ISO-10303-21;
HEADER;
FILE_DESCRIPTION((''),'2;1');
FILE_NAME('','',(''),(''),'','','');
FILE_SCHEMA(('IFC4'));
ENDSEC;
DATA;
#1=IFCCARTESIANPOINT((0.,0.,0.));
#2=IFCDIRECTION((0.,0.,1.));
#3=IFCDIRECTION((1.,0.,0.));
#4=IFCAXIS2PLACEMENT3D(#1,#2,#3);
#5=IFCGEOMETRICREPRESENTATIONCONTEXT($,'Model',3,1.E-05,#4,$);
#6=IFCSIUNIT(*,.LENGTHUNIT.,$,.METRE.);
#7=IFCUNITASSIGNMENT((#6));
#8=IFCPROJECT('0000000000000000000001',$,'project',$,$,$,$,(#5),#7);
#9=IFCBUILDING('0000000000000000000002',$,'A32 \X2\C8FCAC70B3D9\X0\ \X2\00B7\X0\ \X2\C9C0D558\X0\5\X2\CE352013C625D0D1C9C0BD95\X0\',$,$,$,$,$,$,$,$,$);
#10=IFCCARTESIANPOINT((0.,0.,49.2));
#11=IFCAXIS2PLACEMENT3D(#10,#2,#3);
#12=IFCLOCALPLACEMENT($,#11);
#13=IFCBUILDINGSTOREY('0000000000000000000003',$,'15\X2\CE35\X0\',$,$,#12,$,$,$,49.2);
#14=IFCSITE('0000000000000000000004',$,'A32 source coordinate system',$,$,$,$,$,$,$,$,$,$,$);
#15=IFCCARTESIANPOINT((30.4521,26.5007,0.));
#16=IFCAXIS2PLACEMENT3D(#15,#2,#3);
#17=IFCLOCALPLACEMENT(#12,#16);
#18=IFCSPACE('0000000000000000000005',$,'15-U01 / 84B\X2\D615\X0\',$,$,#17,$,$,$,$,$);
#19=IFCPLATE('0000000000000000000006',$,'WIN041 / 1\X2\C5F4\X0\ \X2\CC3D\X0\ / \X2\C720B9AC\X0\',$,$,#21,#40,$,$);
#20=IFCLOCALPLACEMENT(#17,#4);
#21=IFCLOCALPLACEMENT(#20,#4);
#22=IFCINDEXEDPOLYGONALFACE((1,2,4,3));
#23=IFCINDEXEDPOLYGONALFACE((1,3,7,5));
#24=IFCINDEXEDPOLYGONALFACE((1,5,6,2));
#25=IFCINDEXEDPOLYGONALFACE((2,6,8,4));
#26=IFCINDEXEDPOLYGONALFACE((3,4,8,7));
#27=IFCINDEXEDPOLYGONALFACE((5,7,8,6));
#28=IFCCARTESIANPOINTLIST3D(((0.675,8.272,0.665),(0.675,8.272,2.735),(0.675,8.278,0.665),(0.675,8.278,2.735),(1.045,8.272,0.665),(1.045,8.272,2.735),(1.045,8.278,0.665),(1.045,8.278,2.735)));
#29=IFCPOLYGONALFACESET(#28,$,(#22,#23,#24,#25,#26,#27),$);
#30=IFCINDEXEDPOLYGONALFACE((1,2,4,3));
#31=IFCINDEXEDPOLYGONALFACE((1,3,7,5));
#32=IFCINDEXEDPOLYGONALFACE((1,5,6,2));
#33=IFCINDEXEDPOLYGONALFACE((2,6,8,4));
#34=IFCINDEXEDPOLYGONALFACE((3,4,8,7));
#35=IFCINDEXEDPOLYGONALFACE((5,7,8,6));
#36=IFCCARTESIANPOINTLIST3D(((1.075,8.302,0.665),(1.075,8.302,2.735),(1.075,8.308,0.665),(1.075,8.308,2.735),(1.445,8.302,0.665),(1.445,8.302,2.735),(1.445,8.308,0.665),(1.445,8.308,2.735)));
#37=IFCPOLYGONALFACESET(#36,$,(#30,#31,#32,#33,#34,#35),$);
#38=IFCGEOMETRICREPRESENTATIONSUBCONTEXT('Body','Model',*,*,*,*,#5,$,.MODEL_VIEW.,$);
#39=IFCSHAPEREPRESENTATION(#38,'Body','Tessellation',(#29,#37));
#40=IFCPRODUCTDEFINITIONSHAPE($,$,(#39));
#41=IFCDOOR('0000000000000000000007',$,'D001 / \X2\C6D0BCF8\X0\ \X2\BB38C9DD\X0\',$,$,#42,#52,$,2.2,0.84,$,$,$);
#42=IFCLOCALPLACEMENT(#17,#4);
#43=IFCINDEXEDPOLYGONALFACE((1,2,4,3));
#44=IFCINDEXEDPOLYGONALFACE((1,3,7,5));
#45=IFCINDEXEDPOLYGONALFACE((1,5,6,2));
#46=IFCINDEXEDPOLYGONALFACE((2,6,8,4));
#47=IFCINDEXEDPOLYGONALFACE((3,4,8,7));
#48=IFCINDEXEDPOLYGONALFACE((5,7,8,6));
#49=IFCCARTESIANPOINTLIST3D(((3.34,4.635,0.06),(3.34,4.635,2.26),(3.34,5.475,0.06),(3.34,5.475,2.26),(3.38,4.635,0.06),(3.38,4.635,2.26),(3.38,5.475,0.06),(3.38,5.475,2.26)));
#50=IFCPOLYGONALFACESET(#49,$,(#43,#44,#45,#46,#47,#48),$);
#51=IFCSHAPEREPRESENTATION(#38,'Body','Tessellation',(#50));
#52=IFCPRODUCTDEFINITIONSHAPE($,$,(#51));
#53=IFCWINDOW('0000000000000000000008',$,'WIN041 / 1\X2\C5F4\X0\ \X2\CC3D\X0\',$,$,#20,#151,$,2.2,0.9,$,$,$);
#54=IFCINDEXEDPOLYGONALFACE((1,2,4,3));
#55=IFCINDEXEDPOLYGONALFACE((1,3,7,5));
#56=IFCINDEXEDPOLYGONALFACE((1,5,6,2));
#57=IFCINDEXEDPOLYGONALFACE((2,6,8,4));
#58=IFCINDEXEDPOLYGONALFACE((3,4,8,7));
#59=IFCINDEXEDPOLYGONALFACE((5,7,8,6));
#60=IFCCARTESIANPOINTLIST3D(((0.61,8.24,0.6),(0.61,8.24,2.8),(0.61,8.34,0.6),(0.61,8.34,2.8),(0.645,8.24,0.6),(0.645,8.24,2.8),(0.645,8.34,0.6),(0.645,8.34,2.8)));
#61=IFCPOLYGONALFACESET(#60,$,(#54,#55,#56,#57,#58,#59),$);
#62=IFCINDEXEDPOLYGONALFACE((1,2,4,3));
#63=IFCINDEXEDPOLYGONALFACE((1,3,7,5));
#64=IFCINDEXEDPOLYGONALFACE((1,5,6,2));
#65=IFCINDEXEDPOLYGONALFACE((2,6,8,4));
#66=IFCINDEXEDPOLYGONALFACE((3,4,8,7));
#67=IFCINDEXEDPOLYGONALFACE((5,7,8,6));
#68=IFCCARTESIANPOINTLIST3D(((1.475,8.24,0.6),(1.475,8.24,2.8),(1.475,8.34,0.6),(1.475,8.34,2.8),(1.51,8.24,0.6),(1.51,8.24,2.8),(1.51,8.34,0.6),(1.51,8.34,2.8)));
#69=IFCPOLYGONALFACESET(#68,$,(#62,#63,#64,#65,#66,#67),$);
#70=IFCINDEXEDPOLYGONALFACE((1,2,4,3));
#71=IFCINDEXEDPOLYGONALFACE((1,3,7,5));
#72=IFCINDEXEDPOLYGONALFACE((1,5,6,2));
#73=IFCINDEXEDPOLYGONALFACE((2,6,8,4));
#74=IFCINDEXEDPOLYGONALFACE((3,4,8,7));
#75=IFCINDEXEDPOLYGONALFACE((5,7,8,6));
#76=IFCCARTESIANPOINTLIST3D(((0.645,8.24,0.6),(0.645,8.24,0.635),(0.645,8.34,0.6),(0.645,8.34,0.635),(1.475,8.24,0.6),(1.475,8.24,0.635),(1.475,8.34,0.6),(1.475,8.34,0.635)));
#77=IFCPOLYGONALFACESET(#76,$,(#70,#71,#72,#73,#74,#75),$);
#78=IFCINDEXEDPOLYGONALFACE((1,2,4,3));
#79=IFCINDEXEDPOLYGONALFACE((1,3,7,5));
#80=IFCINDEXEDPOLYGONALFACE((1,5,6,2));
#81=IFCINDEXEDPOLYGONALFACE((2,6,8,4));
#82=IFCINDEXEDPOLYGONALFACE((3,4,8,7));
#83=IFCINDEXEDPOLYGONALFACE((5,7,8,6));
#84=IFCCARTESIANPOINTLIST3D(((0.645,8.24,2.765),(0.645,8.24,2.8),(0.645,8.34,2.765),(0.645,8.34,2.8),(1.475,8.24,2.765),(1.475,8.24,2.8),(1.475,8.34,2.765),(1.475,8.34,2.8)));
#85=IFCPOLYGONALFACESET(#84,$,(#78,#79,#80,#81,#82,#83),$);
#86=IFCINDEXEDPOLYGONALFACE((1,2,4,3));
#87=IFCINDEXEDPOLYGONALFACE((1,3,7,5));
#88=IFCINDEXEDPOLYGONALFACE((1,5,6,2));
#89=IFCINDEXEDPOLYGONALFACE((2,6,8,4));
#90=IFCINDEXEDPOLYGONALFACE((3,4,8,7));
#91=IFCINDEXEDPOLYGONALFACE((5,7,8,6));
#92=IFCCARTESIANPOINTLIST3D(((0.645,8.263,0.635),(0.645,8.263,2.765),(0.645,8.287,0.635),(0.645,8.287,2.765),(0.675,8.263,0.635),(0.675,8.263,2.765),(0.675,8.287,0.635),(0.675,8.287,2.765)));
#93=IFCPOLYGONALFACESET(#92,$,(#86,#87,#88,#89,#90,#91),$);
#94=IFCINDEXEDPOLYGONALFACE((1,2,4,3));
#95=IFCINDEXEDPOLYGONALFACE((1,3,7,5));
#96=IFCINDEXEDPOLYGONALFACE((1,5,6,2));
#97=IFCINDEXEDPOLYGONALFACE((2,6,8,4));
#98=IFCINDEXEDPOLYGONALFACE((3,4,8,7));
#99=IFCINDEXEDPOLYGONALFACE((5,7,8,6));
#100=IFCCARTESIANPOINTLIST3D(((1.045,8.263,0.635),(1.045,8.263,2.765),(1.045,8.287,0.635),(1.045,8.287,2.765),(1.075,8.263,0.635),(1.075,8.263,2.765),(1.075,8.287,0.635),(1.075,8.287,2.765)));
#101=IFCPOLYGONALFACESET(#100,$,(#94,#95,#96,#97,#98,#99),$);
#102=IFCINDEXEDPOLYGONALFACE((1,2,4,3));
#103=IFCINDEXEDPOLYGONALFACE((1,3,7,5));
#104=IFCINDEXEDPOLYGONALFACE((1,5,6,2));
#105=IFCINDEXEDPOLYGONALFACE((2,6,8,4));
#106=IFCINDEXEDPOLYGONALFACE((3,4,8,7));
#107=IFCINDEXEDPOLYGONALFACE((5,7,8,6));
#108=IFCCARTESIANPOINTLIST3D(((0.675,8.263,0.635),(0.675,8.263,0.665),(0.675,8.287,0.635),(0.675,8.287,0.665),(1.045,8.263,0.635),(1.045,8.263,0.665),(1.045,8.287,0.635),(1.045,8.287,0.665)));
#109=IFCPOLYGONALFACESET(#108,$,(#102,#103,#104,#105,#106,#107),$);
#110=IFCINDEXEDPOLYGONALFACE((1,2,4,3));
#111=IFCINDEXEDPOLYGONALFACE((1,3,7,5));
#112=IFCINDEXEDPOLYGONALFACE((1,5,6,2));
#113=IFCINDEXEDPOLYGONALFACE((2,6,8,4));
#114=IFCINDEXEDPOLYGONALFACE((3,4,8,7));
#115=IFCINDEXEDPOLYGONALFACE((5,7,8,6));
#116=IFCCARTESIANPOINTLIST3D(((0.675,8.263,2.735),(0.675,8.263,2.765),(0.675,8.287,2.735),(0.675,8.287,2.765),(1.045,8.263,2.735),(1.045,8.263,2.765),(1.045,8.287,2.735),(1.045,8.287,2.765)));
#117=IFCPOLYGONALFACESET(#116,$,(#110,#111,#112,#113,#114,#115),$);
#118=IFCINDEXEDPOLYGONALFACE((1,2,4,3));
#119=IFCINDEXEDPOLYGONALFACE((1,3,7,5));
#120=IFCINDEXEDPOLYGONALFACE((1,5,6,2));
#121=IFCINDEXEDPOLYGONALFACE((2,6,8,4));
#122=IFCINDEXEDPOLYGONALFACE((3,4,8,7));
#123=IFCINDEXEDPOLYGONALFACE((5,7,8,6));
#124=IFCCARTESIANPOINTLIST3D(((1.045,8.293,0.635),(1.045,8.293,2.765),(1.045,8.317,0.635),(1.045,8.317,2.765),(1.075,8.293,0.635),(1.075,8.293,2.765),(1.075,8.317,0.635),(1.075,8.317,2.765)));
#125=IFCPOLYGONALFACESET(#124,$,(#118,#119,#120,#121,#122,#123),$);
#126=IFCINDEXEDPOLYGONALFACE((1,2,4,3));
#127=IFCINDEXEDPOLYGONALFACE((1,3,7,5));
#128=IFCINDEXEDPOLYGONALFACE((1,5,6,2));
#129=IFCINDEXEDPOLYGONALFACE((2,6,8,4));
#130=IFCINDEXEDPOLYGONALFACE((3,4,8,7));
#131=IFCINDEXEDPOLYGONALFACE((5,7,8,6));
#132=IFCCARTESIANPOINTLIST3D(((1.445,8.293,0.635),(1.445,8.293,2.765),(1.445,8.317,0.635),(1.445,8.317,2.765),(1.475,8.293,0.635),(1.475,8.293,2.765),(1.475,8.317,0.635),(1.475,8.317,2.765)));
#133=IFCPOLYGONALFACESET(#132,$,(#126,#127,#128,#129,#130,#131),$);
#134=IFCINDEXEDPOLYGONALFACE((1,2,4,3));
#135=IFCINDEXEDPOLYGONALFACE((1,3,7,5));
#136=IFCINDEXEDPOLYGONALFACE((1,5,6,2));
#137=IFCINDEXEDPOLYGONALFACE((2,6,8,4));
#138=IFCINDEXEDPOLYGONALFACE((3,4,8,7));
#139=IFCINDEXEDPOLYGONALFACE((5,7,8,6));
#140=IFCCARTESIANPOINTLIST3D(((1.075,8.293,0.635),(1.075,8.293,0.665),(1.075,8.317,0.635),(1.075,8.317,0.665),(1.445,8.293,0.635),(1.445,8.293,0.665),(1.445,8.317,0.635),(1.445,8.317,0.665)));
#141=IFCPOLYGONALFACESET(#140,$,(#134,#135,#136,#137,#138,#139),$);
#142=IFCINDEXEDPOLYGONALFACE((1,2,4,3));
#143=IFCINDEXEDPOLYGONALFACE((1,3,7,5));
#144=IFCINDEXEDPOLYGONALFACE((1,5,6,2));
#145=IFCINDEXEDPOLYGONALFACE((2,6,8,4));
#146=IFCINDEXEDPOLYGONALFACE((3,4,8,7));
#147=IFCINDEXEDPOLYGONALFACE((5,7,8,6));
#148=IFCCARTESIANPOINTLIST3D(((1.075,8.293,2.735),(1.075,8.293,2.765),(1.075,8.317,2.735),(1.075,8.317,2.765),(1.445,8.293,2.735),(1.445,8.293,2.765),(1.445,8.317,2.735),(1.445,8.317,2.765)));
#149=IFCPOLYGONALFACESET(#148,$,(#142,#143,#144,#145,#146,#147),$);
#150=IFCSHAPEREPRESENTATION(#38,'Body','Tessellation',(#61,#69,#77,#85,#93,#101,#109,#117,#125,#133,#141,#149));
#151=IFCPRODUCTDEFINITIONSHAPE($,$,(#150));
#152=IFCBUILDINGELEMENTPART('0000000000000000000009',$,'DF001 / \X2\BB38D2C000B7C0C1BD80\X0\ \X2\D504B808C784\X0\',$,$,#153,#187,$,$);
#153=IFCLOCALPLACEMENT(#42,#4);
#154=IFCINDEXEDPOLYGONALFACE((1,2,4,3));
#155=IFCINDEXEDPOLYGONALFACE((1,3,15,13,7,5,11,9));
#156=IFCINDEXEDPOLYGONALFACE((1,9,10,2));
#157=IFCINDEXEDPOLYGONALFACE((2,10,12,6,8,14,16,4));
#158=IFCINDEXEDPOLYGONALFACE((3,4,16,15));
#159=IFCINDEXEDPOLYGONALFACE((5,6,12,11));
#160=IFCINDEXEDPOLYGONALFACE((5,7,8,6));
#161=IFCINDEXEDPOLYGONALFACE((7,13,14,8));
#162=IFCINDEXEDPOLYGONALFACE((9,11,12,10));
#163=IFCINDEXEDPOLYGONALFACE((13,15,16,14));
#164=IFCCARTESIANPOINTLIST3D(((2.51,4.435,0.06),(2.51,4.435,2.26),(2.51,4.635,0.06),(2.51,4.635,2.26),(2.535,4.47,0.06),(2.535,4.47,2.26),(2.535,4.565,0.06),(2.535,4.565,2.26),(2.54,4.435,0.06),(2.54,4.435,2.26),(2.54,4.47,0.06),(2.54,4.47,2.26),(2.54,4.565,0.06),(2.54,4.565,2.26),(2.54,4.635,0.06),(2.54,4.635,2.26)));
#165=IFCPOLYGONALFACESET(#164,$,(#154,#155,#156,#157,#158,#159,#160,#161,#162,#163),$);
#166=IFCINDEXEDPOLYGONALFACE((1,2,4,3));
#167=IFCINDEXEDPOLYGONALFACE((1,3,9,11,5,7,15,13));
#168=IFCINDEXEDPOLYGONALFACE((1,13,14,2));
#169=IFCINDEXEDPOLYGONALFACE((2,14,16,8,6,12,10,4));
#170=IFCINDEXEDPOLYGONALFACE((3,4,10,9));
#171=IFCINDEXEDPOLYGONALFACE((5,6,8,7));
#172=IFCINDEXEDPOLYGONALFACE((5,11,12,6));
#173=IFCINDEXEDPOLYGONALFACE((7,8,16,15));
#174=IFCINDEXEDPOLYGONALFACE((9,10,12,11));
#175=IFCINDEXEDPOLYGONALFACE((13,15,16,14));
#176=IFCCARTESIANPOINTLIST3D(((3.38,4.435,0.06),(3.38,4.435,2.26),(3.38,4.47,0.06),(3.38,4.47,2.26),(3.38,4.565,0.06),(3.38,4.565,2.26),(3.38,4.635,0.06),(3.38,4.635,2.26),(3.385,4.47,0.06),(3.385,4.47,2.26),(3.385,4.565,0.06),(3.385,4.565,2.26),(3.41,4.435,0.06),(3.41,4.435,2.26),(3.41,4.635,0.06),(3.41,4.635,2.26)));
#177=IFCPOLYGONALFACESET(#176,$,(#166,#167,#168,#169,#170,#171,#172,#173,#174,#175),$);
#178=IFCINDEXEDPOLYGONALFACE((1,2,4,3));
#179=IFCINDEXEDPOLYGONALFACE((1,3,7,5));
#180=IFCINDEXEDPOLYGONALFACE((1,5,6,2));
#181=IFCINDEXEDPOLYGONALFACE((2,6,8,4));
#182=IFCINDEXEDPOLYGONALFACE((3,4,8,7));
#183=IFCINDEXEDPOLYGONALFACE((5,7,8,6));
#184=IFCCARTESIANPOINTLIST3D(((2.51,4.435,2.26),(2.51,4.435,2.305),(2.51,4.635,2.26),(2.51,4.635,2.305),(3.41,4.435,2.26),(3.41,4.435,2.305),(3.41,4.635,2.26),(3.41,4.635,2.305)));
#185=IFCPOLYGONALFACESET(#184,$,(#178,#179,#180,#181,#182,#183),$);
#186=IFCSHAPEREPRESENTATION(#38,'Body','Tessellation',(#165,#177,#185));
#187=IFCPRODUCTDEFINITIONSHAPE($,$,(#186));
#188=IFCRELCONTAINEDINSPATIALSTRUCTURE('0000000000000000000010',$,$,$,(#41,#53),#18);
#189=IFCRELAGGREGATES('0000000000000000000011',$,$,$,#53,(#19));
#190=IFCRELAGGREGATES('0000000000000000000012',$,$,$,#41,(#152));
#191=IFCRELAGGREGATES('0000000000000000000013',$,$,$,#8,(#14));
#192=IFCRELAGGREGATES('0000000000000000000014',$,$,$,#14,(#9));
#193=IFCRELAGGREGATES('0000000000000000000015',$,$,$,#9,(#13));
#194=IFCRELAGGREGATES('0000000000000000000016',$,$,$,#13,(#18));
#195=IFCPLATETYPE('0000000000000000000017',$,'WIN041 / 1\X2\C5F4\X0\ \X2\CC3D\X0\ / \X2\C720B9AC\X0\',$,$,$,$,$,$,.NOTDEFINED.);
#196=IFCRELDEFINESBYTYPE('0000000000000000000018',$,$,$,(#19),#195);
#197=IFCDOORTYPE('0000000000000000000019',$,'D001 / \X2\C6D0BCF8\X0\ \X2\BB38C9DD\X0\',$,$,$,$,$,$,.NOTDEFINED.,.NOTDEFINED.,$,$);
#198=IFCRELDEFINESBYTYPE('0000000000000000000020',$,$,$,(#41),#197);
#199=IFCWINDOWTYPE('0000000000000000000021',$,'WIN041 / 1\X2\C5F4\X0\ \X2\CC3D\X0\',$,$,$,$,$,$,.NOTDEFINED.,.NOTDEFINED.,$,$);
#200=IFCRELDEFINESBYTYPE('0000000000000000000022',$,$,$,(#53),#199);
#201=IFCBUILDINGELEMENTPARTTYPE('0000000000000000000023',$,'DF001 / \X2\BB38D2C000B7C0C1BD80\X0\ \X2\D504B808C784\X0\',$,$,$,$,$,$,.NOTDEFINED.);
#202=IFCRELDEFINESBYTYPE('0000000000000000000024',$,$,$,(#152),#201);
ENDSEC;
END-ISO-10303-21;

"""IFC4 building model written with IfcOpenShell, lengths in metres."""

from ifc_helpers import new_model, si_unit, frame, origin, origin_with_axes, place, context, subcontext, project, spatial, polyline, outline, extrude, source, transform, mapped, type_object, type_shapes, element, aggregate, save


model = new_model("IFC4")

# Units and contexts
model_context = context("Model", 3, precision=1e-05, world=origin_with_axes())
body_context = subcontext(model_context, "Body", "Model", "MODEL_VIEW")
ifc_project = project(units=[si_unit("LENGTHUNIT", "METRE")], contexts=[model_context])

# Plate
storey_placement = place(None, frame((0.0, 0.0, 49.2), z_axis=(0.0, 0.0, 1.0), x_axis=(1.0, 0.0, 0.0)))
space_placement = place(storey_placement, frame((30.4521, 26.5007, 0.0), z_axis=(0.0, 0.0, 1.0), x_axis=(1.0, 0.0, 0.0)))
plate_type_1 = type_object("IfcPlateType", Name="WIN041 / 1열 창 / 유리", PredefinedType="NOTDEFINED")
shared_shape_1 = source(origin(), body_context, "Body", "SweptSolid", [
    extrude(outline(polyline([(0.675, 8.272), (0.675, 8.278), (1.045, 8.278), (1.045, 8.272), (0.675, 8.272)])), frame((0.0, 0.0, 0.665)), (0.0, 0.0, 1.0), 2.07),
    extrude(outline(polyline([(1.075, 8.302), (1.075, 8.308), (1.445, 8.308), (1.445, 8.302), (1.075, 8.302)])), frame((0.0, 0.0, 0.665)), (0.0, 0.0, 1.0), 2.07),
])
type_shapes(plate_type_1, [shared_shape_1])
window_1_placement = place(space_placement, origin_with_axes())
plate_1_placement = place(window_1_placement, origin_with_axes())
plate_1 = element("IfcPlate", 1, at=plate_1_placement, type_object=plate_type_1, Name="WIN041 / 1열 창 / 유리", context=body_context, shape_type="MappedRepresentation", body=[
    mapped(shared_shape_1, transform((0.0, 0.0, 0.0), scale=1.0)),
])

# Site, building, storey, space
site = spatial("IfcSite", under=ifc_project, Name="A32 source coordinate system")
building = spatial("IfcBuilding", under=site, Name="A32 주거동 · 지하5층–옥탑지붕")
storey = spatial("IfcBuildingStorey", under=building, at=storey_placement, Name="15층", Elevation=49.2)
space = spatial("IfcSpace", under=storey, at=space_placement, Name="15-U01 / 84B형")

# Door
door_type_1 = type_object("IfcDoorType", Name="D001 / 원본 문짝", OperationType="NOTDEFINED", PredefinedType="NOTDEFINED")
shared_shape_2 = source(origin(), body_context, "Body", "SweptSolid", [
    extrude(outline(polyline([(3.34, 5.475), (3.38, 5.475), (3.38, 4.635), (3.34, 4.635), (3.34, 5.475)])), frame((0.0, 0.0, 0.06)), (0.0, 0.0, 1.0), 2.2),
])
type_shapes(door_type_1, [shared_shape_2])
door_1_placement = place(space_placement, origin_with_axes())
door_1 = element("IfcDoor", 2, at=door_1_placement, inside=space, type_object=door_type_1, Name="D001 / 원본 문짝", OverallHeight=2.2, OverallWidth=0.84, context=body_context, shape_type="MappedRepresentation", body=[
    mapped(shared_shape_2, transform((0.0, 0.0, 0.0), scale=1.0)),
])

# Window
window_type_1 = type_object("IfcWindowType", Name="WIN041 / 1열 창", PartitioningType="NOTDEFINED", PredefinedType="NOTDEFINED")
shared_shape_3 = source(origin(), body_context, "Body", "SweptSolid", [
    extrude(outline(polyline([(0.61, 8.24), (0.61, 8.34), (0.645, 8.34), (0.645, 8.24), (0.61, 8.24)])), frame((0.0, 0.0, 0.6)), (0.0, 0.0, 1.0), 2.2),
    extrude(outline(polyline([(1.475, 8.24), (1.475, 8.34), (1.51, 8.34), (1.51, 8.24), (1.475, 8.24)])), frame((0.0, 0.0, 0.6)), (0.0, 0.0, 1.0), 2.2),
    extrude(outline(polyline([(0.645, 8.24), (0.645, 8.34), (1.475, 8.34), (1.475, 8.24), (0.645, 8.24)])), frame((0.0, 0.0, 0.6)), (0.0, 0.0, 1.0), 0.035),
    extrude(outline(polyline([(0.645, 8.24), (0.645, 8.34), (1.475, 8.34), (1.475, 8.24), (0.645, 8.24)])), frame((0.0, 0.0, 2.765)), (0.0, 0.0, 1.0), 0.035),
    extrude(outline(polyline([(0.645, 8.263), (0.645, 8.287), (0.675, 8.287), (0.675, 8.263), (0.645, 8.263)])), frame((0.0, 0.0, 0.635)), (0.0, 0.0, 1.0), 2.13),
    extrude(outline(polyline([(1.045, 8.263), (1.045, 8.287), (1.075, 8.287), (1.075, 8.263), (1.045, 8.263)])), frame((0.0, 0.0, 0.635)), (0.0, 0.0, 1.0), 2.13),
    extrude(outline(polyline([(0.675, 8.263), (0.675, 8.287), (1.045, 8.287), (1.045, 8.263), (0.675, 8.263)])), frame((0.0, 0.0, 0.635)), (0.0, 0.0, 1.0), 0.03),
    extrude(outline(polyline([(0.675, 8.263), (0.675, 8.287), (1.045, 8.287), (1.045, 8.263), (0.675, 8.263)])), frame((0.0, 0.0, 2.735)), (0.0, 0.0, 1.0), 0.03),
    extrude(outline(polyline([(1.045, 8.293), (1.045, 8.317), (1.075, 8.317), (1.075, 8.293), (1.045, 8.293)])), frame((0.0, 0.0, 0.635)), (0.0, 0.0, 1.0), 2.13),
    extrude(outline(polyline([(1.445, 8.293), (1.445, 8.317), (1.475, 8.317), (1.475, 8.293), (1.445, 8.293)])), frame((0.0, 0.0, 0.635)), (0.0, 0.0, 1.0), 2.13),
    extrude(outline(polyline([(1.075, 8.293), (1.075, 8.317), (1.445, 8.317), (1.445, 8.293), (1.075, 8.293)])), frame((0.0, 0.0, 0.635)), (0.0, 0.0, 1.0), 0.03),
    extrude(outline(polyline([(1.075, 8.293), (1.075, 8.317), (1.445, 8.317), (1.445, 8.293), (1.075, 8.293)])), frame((0.0, 0.0, 2.735)), (0.0, 0.0, 1.0), 0.03),
])
type_shapes(window_type_1, [shared_shape_3])
window_1 = element("IfcWindow", 3, at=window_1_placement, inside=space, type_object=window_type_1, Name="WIN041 / 1열 창", OverallHeight=2.2, OverallWidth=0.9, context=body_context, shape_type="MappedRepresentation", body=[
    mapped(shared_shape_3, transform((0.0, 0.0, 0.0), scale=1.0)),
])
aggregate(window_1, [plate_1])

# Building element part
building_element_part_type_1 = type_object("IfcBuildingElementPartType", Name="DF001 / 문틀·상부 프레임", PredefinedType="NOTDEFINED")
shared_shape_4 = source(origin(), body_context, "Body", "SweptSolid", [
    extrude(outline(polyline([(2.54, 4.635), (2.54, 4.565), (2.535, 4.565), (2.535, 4.47), (2.54, 4.47), (2.54, 4.435), (2.51, 4.435), (2.51, 4.635), (2.54, 4.635)])), frame((0.0, 0.0, 0.06)), (0.0, 0.0, 1.0), 2.2),
    extrude(outline(polyline([(3.41, 4.435), (3.38, 4.435), (3.38, 4.47), (3.385, 4.47), (3.385, 4.565), (3.38, 4.565), (3.38, 4.635), (3.41, 4.635), (3.41, 4.435)])), frame((0.0, 0.0, 0.06)), (0.0, 0.0, 1.0), 2.2),
    extrude(outline(polyline([(2.51, 4.435), (2.51, 4.635), (3.41, 4.635), (3.41, 4.435), (2.51, 4.435)])), frame((0.0, 0.0, 2.26)), (0.0, 0.0, 1.0), 0.045),
])
type_shapes(building_element_part_type_1, [shared_shape_4])
building_element_part_1_placement = place(door_1_placement, origin_with_axes())
building_element_part_1 = element("IfcBuildingElementPart", 4, at=building_element_part_1_placement, type_object=building_element_part_type_1, Name="DF001 / 문틀·상부 프레임", context=body_context, shape_type="MappedRepresentation", body=[
    mapped(shared_shape_4, transform((0.0, 0.0, 0.0), scale=1.0)),
])
aggregate(door_1, [building_element_part_1])

save(model, "model.ifc")
